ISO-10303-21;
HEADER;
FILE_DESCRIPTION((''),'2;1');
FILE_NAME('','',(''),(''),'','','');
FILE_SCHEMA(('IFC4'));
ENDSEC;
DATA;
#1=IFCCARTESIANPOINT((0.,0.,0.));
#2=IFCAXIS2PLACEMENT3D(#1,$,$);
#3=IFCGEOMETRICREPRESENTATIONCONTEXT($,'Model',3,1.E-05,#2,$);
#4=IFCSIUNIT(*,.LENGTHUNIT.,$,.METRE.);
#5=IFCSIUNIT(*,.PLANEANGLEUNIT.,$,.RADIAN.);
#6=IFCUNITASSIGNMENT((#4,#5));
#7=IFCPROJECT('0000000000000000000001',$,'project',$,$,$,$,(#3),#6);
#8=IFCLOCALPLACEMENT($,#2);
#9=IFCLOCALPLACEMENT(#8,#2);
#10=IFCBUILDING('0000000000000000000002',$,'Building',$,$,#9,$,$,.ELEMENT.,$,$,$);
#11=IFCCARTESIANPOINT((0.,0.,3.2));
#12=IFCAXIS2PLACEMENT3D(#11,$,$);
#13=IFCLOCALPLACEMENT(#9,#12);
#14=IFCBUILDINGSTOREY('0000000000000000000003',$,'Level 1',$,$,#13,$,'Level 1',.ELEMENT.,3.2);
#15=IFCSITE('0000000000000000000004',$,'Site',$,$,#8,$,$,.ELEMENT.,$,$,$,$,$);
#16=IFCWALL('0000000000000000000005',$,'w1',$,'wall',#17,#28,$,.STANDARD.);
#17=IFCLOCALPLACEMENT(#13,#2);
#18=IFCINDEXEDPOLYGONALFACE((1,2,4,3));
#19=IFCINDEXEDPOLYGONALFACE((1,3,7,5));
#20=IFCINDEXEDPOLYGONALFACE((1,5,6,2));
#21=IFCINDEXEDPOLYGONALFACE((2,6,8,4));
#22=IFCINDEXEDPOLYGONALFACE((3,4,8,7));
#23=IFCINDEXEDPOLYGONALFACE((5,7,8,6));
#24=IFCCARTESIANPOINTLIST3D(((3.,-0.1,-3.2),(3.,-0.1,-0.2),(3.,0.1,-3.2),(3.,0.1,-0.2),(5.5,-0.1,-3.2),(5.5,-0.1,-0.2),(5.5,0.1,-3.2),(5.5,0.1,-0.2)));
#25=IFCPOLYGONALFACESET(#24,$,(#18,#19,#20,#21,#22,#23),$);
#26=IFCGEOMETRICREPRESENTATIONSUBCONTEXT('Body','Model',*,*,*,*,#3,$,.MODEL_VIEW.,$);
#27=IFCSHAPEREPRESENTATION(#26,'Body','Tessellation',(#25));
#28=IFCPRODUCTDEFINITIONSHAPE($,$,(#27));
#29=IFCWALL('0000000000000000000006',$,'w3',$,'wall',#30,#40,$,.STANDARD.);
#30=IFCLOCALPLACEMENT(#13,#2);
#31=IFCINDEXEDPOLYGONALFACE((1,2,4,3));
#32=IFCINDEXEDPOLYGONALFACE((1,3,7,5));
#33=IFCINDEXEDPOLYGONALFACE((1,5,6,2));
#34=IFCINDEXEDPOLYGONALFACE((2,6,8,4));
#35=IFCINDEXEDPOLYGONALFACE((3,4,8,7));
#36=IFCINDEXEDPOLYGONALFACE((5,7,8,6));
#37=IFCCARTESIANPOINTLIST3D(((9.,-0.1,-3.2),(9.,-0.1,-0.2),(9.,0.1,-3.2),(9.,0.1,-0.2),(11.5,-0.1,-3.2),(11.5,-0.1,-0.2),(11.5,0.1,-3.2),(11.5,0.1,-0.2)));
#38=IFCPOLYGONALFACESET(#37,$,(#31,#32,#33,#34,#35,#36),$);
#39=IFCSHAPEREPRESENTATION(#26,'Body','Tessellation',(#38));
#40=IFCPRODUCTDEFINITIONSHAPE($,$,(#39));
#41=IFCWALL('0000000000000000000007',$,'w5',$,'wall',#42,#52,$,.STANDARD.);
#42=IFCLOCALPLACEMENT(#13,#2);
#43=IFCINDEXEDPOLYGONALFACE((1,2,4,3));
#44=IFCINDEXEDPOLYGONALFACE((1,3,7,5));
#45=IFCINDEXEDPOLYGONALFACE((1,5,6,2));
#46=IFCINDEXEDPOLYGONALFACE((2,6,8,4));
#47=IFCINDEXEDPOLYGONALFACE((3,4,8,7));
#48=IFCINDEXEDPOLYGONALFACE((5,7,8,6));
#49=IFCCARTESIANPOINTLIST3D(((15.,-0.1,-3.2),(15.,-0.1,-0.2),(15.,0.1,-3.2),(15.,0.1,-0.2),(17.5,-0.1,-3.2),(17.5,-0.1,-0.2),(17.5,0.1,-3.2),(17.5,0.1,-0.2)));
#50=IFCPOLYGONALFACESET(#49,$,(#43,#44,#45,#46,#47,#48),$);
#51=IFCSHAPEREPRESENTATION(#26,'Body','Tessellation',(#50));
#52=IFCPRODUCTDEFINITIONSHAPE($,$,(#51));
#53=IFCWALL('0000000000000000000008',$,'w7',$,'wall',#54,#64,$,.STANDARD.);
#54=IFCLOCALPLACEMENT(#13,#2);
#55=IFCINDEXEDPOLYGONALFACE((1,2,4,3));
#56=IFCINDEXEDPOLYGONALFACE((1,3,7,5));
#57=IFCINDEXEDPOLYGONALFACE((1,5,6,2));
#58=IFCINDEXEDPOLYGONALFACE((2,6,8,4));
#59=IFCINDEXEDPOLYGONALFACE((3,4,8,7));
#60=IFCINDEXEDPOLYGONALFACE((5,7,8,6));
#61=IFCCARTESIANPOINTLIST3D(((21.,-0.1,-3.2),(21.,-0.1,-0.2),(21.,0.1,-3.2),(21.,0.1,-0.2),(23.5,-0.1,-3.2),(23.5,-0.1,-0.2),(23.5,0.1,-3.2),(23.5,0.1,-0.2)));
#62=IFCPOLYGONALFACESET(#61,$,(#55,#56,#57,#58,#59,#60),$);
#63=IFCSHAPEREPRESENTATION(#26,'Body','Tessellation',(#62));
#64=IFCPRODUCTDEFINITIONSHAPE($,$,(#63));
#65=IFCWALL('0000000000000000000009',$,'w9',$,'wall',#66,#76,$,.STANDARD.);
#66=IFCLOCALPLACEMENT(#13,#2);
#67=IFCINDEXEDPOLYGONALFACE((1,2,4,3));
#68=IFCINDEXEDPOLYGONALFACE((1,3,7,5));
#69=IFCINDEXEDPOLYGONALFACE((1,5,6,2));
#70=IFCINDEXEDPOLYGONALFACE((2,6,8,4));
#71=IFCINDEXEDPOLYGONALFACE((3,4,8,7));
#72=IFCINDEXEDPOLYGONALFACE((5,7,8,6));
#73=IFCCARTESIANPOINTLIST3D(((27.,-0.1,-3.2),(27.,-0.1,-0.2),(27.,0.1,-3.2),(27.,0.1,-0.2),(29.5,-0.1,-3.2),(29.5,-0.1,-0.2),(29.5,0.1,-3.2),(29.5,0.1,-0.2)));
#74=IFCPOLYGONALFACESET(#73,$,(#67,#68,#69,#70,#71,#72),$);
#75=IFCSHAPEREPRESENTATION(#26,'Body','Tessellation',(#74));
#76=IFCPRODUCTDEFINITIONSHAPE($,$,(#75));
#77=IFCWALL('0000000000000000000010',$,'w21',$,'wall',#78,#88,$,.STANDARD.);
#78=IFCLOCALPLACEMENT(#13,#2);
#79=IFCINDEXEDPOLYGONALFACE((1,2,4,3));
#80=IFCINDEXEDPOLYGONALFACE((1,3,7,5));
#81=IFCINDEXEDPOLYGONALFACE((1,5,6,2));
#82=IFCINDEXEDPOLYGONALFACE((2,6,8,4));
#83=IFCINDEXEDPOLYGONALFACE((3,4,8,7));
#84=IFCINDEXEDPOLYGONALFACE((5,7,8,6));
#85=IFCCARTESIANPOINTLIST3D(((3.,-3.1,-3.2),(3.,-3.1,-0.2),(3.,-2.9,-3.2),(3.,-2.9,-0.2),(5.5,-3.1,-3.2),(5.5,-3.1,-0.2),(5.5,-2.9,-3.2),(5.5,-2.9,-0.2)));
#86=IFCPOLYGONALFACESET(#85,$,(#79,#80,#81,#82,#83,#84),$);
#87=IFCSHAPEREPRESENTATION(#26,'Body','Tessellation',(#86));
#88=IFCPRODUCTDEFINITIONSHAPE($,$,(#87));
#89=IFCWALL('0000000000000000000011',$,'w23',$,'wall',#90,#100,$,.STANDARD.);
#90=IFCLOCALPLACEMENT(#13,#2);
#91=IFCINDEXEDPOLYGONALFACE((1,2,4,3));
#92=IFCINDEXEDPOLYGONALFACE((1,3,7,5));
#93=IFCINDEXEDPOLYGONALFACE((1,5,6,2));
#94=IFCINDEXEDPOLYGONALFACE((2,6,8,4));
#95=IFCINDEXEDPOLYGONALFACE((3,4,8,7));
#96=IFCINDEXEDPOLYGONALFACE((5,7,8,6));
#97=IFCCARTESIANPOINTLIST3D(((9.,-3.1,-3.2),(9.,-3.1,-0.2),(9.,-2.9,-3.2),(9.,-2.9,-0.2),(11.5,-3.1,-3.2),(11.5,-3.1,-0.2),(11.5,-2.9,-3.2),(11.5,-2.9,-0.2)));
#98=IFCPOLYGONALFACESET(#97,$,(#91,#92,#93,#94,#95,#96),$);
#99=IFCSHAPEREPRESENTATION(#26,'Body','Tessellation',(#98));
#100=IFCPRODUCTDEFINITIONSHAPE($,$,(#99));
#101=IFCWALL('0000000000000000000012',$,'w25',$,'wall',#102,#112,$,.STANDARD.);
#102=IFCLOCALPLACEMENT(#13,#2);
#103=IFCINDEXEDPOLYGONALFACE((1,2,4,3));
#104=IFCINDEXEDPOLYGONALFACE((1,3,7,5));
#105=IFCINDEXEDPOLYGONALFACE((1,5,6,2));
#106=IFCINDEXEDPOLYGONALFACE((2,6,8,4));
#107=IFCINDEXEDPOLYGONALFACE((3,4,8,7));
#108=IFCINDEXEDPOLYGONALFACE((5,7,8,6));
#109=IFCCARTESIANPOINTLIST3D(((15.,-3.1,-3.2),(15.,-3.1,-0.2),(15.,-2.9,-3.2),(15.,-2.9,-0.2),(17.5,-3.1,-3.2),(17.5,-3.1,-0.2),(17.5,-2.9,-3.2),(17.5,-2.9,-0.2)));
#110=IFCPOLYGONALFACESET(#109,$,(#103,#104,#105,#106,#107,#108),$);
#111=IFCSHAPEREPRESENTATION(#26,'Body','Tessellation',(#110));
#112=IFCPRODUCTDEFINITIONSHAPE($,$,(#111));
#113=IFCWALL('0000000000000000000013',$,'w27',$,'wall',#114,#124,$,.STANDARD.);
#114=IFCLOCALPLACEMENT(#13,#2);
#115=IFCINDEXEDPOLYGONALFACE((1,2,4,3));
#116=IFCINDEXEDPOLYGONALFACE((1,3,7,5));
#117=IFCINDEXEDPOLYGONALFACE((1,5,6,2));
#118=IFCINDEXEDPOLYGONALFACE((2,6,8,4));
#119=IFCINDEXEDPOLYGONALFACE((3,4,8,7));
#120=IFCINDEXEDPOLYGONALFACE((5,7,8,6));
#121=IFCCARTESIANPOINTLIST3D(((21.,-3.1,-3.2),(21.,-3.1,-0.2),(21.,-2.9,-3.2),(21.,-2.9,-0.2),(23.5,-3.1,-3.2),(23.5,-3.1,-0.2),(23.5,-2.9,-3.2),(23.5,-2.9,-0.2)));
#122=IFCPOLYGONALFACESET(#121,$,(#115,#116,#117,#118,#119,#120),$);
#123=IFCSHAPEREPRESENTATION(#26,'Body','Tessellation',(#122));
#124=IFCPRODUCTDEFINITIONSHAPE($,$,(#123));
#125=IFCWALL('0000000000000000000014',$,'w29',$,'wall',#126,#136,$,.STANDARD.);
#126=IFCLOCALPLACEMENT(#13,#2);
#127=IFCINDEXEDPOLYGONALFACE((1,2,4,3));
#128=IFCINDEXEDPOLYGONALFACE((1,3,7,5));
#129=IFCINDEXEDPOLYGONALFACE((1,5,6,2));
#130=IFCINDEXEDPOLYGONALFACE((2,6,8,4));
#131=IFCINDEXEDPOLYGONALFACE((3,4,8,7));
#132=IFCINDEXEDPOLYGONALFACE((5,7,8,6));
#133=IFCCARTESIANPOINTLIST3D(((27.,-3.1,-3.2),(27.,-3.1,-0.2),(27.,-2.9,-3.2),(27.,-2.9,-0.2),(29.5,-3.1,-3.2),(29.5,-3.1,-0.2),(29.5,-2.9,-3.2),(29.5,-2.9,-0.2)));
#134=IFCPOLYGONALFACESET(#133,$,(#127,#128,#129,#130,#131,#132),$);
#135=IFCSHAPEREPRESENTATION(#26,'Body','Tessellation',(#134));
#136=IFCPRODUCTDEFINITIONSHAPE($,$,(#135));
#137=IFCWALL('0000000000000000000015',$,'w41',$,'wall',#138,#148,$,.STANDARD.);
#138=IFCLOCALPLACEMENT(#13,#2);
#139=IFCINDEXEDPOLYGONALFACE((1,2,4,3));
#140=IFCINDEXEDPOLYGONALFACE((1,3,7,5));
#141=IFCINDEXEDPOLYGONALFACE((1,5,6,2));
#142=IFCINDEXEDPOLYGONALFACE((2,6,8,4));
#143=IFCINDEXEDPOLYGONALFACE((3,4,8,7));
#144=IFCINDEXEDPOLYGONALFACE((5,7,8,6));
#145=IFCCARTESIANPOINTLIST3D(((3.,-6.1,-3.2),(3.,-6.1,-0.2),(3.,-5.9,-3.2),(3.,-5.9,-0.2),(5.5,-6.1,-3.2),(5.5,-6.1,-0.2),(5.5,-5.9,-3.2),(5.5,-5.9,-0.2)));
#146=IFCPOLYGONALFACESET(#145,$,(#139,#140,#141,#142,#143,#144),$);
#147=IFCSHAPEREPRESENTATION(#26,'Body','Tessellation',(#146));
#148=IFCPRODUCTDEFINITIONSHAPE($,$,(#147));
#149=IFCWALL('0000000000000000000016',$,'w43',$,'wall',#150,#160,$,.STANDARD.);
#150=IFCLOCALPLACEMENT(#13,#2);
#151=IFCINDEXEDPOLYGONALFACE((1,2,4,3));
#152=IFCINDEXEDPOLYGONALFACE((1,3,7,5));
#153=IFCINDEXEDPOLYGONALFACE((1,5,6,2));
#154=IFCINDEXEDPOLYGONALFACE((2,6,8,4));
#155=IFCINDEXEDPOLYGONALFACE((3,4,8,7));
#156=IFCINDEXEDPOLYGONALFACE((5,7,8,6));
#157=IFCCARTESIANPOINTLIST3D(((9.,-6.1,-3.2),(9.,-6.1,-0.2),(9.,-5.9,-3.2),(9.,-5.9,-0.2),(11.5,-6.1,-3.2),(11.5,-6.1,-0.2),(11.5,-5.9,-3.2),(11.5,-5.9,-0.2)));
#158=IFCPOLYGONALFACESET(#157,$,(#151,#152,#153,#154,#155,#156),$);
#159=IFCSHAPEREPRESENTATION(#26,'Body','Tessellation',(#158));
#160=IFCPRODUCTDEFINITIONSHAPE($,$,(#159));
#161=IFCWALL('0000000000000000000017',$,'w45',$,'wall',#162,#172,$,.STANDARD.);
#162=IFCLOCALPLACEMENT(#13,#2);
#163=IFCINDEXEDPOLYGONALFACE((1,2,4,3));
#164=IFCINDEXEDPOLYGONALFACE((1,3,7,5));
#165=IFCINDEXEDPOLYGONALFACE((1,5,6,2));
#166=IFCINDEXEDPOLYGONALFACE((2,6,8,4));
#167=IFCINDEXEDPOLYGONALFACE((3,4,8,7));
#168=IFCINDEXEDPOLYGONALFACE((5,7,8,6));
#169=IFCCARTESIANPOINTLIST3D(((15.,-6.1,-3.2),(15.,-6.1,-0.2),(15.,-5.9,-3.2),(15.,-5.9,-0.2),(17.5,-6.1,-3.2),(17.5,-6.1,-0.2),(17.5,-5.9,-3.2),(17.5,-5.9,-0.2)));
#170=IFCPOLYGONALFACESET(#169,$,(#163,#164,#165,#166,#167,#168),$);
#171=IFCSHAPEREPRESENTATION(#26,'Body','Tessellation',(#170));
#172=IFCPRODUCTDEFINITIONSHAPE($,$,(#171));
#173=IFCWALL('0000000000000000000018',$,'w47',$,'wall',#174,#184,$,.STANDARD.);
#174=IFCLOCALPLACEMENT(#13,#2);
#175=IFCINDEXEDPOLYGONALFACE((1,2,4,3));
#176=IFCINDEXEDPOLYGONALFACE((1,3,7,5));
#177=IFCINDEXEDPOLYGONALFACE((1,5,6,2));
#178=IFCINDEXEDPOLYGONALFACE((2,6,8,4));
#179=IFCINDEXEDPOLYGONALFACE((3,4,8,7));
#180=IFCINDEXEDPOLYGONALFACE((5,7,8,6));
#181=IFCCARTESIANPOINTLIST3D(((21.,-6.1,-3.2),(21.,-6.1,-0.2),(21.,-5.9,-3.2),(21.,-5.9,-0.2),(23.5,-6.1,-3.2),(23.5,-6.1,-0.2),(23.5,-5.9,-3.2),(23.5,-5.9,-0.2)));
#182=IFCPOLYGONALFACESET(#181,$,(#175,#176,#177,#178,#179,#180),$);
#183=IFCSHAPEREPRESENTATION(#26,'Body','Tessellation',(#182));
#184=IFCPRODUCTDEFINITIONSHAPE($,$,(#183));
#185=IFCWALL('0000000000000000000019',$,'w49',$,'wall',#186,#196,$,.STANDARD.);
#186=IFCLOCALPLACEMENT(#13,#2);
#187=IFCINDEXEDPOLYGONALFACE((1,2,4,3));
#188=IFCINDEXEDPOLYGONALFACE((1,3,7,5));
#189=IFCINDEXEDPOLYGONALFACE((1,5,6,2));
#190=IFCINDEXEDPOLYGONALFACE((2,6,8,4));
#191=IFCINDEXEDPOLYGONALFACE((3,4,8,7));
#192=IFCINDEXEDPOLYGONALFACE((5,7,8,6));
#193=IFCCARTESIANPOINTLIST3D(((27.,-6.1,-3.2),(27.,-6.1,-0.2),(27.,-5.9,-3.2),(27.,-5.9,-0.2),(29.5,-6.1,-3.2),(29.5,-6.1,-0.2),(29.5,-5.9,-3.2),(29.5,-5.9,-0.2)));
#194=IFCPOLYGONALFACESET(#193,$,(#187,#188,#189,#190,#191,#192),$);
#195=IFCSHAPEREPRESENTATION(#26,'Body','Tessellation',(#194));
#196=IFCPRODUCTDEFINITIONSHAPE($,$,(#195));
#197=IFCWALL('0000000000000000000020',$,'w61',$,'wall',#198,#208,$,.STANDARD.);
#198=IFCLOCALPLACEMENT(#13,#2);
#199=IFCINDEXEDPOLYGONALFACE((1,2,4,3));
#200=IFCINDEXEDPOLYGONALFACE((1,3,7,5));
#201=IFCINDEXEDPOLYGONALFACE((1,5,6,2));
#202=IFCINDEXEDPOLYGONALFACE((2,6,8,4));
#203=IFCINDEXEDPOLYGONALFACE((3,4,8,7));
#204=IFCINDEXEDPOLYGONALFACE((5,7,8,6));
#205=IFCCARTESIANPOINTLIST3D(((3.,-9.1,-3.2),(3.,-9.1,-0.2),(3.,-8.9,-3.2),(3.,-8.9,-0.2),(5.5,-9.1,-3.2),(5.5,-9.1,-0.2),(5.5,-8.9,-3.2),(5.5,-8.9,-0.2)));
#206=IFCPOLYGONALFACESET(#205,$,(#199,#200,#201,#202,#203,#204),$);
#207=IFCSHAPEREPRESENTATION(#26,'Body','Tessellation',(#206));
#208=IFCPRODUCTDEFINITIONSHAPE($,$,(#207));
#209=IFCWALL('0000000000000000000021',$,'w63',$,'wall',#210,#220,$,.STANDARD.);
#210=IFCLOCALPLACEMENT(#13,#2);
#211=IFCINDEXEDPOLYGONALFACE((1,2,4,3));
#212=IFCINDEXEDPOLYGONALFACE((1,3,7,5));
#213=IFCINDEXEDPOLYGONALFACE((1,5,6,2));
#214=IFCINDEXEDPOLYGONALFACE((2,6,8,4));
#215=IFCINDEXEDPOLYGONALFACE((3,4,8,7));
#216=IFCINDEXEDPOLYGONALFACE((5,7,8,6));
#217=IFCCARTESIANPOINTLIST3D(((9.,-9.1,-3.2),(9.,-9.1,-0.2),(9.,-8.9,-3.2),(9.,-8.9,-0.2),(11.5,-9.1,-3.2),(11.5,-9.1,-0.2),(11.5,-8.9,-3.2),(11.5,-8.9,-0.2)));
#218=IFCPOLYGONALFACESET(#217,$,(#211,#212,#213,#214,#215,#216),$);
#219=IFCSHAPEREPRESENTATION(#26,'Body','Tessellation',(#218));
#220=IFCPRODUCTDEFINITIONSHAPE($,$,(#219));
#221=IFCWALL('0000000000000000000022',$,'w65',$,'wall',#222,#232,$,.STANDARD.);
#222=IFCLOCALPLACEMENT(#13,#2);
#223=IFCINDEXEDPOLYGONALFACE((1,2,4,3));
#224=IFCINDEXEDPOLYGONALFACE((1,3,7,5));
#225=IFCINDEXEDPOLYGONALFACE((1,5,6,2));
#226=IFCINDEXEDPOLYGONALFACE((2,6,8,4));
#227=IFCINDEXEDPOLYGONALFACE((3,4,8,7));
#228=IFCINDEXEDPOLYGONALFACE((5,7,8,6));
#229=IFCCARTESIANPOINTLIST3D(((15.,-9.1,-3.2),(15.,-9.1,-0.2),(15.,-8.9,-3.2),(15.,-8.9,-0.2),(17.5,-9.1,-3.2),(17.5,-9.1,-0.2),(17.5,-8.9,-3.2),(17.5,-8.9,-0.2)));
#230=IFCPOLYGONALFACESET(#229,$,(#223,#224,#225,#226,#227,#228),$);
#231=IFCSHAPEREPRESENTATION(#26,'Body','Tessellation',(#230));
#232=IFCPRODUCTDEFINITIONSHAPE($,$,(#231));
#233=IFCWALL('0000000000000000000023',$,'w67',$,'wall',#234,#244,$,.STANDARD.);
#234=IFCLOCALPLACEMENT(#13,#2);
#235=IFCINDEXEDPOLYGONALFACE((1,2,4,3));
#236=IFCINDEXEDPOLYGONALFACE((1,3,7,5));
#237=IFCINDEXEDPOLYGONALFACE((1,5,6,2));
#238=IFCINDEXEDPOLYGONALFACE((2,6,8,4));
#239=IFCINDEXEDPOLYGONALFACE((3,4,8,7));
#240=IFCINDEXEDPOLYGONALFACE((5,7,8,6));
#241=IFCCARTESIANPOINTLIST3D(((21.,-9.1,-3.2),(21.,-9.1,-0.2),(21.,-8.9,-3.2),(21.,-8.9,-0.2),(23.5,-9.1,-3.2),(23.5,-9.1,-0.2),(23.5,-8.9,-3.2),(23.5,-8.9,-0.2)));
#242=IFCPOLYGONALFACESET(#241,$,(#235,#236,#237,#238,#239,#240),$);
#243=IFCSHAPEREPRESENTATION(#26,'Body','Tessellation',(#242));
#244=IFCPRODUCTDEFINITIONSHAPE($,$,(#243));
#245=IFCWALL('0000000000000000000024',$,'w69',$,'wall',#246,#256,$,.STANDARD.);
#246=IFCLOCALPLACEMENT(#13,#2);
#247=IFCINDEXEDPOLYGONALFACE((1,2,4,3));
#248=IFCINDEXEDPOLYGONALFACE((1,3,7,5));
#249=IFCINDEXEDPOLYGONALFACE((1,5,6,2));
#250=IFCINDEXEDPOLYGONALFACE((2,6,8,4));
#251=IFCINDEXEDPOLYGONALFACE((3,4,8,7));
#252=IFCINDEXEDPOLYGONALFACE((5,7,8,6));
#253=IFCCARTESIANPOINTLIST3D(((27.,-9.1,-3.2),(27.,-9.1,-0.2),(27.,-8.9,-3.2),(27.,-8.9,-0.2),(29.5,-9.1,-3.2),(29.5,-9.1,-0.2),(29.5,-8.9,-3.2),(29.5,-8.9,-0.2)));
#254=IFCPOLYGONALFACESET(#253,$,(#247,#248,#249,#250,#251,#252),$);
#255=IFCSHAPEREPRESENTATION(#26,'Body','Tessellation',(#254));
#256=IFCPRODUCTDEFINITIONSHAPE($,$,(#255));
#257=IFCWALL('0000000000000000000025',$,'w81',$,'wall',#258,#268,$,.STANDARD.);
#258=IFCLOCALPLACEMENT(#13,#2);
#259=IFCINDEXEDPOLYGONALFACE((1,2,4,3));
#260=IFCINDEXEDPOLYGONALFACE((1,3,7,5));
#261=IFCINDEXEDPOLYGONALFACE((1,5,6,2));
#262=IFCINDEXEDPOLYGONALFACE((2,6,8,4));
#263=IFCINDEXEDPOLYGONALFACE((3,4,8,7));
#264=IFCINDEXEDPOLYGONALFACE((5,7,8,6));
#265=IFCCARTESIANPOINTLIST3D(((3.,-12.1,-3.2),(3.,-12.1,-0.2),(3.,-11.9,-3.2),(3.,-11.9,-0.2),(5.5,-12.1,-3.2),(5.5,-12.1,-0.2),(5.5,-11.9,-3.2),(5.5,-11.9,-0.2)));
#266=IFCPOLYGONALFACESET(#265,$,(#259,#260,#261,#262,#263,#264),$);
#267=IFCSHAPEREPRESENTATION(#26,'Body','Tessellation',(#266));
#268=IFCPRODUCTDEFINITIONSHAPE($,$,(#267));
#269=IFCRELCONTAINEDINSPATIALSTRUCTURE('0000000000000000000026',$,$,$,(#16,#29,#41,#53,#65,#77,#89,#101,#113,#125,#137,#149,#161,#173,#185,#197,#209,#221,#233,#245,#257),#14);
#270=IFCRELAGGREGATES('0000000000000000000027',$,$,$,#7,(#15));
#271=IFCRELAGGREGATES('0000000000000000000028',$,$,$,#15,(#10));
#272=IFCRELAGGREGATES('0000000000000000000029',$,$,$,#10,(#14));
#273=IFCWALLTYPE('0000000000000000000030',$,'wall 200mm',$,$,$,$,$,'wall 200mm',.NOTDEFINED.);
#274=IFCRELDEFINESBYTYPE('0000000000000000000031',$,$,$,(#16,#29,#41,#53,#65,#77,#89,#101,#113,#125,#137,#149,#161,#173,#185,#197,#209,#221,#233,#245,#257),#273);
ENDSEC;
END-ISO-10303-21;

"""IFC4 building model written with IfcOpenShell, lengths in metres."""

from ifc_helpers import new_model, si_unit, frame, frame_2d, origin, place, context, subcontext, project, spatial, rectangle, extrude, type_object, element, save


model = new_model("IFC4")

# Units and contexts
model_context = context("Model", 3, precision=1e-05, world=origin())
body_context = subcontext(model_context, "Body", "Model", "MODEL_VIEW")
ifc_project = project(units=[si_unit("LENGTHUNIT", "METRE"), si_unit("PLANEANGLEUNIT", "RADIAN")], contexts=[model_context])

# Site, building, storey
site_placement = place(None, origin())
site = spatial("IfcSite", under=ifc_project, at=site_placement, Name="Site", CompositionType="ELEMENT")
building_placement = place(site_placement, origin())
building = spatial("IfcBuilding", under=site, at=building_placement, Name="Building", CompositionType="ELEMENT")
storey_placement = place(building_placement, frame((0.0, 0.0, 3.2)))
storey = spatial("IfcBuildingStorey", under=building, at=storey_placement, Name="Level 1", LongName="Level 1", CompositionType="ELEMENT", Elevation=3.2)

# Walls
wall_type = type_object("IfcWallType", Name="wall 200mm", ElementType="wall 200mm", PredefinedType="NOTDEFINED")
for number, where, z_axis, x_axis, name in (
    (1, (3.0, 0.0, -3.2), (0.0, 0.0, 1.0), (1.0, 0.0, 0.0), "w1"),
    (2, (9.0, 0.0, -3.2), (0.0, 0.0, 1.0), (1.0, 0.0, 0.0), "w3"),
    (3, (15.0, 0.0, -3.2), (0.0, 0.0, 1.0), (1.0, 0.0, 0.0), "w5"),
    (4, (21.0, 0.0, -3.2), (0.0, 0.0, 1.0), (1.0, 0.0, 0.0), "w7"),
    (5, (27.0, 0.0, -3.2), (0.0, 0.0, 1.0), (1.0, 0.0, 0.0), "w9"),
    (6, (3.0, -3.0, -3.2), (0.0, 0.0, 1.0), (1.0, 0.0, 0.0), "w21"),
    (7, (9.0, -3.0, -3.2), (0.0, 0.0, 1.0), (1.0, 0.0, 0.0), "w23"),
    (8, (15.0, -3.0, -3.2), (0.0, 0.0, 1.0), (1.0, 0.0, 0.0), "w25"),
    (9, (21.0, -3.0, -3.2), (0.0, 0.0, 1.0), (1.0, 0.0, 0.0), "w27"),
    (10, (27.0, -3.0, -3.2), (0.0, 0.0, 1.0), (1.0, 0.0, 0.0), "w29"),
    (11, (3.0, -6.0, -3.2), (0.0, 0.0, 1.0), (1.0, 0.0, 0.0), "w41"),
    (12, (9.0, -6.0, -3.2), (0.0, 0.0, 1.0), (1.0, 0.0, 0.0), "w43"),
    (13, (15.0, -6.0, -3.2), (0.0, 0.0, 1.0), (1.0, 0.0, 0.0), "w45"),
    (14, (21.0, -6.0, -3.2), (0.0, 0.0, 1.0), (1.0, 0.0, 0.0), "w47"),
    (15, (27.0, -6.0, -3.2), (0.0, 0.0, 1.0), (1.0, 0.0, 0.0), "w49"),
    (16, (3.0, -9.0, -3.2), (0.0, 0.0, 1.0), (1.0, 0.0, 0.0), "w61"),
    (17, (9.0, -9.0, -3.2), (0.0, 0.0, 1.0), (1.0, 0.0, 0.0), "w63"),
    (18, (15.0, -9.0, -3.2), (0.0, 0.0, 1.0), (1.0, 0.0, 0.0), "w65"),
    (19, (21.0, -9.0, -3.2), (0.0, 0.0, 1.0), (1.0, 0.0, 0.0), "w67"),
    (20, (27.0, -9.0, -3.2), (0.0, 0.0, 1.0), (1.0, 0.0, 0.0), "w69"),
    (21, (3.0, -12.0, -3.2), (0.0, 0.0, 1.0), (1.0, 0.0, 0.0), "w81"),
):
    element("IfcWall", number, at=place(storey_placement, frame(where, z_axis=z_axis, x_axis=x_axis)), inside=storey, type_object=wall_type, Name=name, ObjectType="wall", PredefinedType="STANDARD", context=body_context, shape_type="SweptSolid", body=[
        extrude(rectangle(XDim=2.5, YDim=0.2, at=frame_2d((1.25, 0.0))), origin(), (0.0, 0.0, 1.0), 3.0),
    ])

save(model, "model.ifc")
